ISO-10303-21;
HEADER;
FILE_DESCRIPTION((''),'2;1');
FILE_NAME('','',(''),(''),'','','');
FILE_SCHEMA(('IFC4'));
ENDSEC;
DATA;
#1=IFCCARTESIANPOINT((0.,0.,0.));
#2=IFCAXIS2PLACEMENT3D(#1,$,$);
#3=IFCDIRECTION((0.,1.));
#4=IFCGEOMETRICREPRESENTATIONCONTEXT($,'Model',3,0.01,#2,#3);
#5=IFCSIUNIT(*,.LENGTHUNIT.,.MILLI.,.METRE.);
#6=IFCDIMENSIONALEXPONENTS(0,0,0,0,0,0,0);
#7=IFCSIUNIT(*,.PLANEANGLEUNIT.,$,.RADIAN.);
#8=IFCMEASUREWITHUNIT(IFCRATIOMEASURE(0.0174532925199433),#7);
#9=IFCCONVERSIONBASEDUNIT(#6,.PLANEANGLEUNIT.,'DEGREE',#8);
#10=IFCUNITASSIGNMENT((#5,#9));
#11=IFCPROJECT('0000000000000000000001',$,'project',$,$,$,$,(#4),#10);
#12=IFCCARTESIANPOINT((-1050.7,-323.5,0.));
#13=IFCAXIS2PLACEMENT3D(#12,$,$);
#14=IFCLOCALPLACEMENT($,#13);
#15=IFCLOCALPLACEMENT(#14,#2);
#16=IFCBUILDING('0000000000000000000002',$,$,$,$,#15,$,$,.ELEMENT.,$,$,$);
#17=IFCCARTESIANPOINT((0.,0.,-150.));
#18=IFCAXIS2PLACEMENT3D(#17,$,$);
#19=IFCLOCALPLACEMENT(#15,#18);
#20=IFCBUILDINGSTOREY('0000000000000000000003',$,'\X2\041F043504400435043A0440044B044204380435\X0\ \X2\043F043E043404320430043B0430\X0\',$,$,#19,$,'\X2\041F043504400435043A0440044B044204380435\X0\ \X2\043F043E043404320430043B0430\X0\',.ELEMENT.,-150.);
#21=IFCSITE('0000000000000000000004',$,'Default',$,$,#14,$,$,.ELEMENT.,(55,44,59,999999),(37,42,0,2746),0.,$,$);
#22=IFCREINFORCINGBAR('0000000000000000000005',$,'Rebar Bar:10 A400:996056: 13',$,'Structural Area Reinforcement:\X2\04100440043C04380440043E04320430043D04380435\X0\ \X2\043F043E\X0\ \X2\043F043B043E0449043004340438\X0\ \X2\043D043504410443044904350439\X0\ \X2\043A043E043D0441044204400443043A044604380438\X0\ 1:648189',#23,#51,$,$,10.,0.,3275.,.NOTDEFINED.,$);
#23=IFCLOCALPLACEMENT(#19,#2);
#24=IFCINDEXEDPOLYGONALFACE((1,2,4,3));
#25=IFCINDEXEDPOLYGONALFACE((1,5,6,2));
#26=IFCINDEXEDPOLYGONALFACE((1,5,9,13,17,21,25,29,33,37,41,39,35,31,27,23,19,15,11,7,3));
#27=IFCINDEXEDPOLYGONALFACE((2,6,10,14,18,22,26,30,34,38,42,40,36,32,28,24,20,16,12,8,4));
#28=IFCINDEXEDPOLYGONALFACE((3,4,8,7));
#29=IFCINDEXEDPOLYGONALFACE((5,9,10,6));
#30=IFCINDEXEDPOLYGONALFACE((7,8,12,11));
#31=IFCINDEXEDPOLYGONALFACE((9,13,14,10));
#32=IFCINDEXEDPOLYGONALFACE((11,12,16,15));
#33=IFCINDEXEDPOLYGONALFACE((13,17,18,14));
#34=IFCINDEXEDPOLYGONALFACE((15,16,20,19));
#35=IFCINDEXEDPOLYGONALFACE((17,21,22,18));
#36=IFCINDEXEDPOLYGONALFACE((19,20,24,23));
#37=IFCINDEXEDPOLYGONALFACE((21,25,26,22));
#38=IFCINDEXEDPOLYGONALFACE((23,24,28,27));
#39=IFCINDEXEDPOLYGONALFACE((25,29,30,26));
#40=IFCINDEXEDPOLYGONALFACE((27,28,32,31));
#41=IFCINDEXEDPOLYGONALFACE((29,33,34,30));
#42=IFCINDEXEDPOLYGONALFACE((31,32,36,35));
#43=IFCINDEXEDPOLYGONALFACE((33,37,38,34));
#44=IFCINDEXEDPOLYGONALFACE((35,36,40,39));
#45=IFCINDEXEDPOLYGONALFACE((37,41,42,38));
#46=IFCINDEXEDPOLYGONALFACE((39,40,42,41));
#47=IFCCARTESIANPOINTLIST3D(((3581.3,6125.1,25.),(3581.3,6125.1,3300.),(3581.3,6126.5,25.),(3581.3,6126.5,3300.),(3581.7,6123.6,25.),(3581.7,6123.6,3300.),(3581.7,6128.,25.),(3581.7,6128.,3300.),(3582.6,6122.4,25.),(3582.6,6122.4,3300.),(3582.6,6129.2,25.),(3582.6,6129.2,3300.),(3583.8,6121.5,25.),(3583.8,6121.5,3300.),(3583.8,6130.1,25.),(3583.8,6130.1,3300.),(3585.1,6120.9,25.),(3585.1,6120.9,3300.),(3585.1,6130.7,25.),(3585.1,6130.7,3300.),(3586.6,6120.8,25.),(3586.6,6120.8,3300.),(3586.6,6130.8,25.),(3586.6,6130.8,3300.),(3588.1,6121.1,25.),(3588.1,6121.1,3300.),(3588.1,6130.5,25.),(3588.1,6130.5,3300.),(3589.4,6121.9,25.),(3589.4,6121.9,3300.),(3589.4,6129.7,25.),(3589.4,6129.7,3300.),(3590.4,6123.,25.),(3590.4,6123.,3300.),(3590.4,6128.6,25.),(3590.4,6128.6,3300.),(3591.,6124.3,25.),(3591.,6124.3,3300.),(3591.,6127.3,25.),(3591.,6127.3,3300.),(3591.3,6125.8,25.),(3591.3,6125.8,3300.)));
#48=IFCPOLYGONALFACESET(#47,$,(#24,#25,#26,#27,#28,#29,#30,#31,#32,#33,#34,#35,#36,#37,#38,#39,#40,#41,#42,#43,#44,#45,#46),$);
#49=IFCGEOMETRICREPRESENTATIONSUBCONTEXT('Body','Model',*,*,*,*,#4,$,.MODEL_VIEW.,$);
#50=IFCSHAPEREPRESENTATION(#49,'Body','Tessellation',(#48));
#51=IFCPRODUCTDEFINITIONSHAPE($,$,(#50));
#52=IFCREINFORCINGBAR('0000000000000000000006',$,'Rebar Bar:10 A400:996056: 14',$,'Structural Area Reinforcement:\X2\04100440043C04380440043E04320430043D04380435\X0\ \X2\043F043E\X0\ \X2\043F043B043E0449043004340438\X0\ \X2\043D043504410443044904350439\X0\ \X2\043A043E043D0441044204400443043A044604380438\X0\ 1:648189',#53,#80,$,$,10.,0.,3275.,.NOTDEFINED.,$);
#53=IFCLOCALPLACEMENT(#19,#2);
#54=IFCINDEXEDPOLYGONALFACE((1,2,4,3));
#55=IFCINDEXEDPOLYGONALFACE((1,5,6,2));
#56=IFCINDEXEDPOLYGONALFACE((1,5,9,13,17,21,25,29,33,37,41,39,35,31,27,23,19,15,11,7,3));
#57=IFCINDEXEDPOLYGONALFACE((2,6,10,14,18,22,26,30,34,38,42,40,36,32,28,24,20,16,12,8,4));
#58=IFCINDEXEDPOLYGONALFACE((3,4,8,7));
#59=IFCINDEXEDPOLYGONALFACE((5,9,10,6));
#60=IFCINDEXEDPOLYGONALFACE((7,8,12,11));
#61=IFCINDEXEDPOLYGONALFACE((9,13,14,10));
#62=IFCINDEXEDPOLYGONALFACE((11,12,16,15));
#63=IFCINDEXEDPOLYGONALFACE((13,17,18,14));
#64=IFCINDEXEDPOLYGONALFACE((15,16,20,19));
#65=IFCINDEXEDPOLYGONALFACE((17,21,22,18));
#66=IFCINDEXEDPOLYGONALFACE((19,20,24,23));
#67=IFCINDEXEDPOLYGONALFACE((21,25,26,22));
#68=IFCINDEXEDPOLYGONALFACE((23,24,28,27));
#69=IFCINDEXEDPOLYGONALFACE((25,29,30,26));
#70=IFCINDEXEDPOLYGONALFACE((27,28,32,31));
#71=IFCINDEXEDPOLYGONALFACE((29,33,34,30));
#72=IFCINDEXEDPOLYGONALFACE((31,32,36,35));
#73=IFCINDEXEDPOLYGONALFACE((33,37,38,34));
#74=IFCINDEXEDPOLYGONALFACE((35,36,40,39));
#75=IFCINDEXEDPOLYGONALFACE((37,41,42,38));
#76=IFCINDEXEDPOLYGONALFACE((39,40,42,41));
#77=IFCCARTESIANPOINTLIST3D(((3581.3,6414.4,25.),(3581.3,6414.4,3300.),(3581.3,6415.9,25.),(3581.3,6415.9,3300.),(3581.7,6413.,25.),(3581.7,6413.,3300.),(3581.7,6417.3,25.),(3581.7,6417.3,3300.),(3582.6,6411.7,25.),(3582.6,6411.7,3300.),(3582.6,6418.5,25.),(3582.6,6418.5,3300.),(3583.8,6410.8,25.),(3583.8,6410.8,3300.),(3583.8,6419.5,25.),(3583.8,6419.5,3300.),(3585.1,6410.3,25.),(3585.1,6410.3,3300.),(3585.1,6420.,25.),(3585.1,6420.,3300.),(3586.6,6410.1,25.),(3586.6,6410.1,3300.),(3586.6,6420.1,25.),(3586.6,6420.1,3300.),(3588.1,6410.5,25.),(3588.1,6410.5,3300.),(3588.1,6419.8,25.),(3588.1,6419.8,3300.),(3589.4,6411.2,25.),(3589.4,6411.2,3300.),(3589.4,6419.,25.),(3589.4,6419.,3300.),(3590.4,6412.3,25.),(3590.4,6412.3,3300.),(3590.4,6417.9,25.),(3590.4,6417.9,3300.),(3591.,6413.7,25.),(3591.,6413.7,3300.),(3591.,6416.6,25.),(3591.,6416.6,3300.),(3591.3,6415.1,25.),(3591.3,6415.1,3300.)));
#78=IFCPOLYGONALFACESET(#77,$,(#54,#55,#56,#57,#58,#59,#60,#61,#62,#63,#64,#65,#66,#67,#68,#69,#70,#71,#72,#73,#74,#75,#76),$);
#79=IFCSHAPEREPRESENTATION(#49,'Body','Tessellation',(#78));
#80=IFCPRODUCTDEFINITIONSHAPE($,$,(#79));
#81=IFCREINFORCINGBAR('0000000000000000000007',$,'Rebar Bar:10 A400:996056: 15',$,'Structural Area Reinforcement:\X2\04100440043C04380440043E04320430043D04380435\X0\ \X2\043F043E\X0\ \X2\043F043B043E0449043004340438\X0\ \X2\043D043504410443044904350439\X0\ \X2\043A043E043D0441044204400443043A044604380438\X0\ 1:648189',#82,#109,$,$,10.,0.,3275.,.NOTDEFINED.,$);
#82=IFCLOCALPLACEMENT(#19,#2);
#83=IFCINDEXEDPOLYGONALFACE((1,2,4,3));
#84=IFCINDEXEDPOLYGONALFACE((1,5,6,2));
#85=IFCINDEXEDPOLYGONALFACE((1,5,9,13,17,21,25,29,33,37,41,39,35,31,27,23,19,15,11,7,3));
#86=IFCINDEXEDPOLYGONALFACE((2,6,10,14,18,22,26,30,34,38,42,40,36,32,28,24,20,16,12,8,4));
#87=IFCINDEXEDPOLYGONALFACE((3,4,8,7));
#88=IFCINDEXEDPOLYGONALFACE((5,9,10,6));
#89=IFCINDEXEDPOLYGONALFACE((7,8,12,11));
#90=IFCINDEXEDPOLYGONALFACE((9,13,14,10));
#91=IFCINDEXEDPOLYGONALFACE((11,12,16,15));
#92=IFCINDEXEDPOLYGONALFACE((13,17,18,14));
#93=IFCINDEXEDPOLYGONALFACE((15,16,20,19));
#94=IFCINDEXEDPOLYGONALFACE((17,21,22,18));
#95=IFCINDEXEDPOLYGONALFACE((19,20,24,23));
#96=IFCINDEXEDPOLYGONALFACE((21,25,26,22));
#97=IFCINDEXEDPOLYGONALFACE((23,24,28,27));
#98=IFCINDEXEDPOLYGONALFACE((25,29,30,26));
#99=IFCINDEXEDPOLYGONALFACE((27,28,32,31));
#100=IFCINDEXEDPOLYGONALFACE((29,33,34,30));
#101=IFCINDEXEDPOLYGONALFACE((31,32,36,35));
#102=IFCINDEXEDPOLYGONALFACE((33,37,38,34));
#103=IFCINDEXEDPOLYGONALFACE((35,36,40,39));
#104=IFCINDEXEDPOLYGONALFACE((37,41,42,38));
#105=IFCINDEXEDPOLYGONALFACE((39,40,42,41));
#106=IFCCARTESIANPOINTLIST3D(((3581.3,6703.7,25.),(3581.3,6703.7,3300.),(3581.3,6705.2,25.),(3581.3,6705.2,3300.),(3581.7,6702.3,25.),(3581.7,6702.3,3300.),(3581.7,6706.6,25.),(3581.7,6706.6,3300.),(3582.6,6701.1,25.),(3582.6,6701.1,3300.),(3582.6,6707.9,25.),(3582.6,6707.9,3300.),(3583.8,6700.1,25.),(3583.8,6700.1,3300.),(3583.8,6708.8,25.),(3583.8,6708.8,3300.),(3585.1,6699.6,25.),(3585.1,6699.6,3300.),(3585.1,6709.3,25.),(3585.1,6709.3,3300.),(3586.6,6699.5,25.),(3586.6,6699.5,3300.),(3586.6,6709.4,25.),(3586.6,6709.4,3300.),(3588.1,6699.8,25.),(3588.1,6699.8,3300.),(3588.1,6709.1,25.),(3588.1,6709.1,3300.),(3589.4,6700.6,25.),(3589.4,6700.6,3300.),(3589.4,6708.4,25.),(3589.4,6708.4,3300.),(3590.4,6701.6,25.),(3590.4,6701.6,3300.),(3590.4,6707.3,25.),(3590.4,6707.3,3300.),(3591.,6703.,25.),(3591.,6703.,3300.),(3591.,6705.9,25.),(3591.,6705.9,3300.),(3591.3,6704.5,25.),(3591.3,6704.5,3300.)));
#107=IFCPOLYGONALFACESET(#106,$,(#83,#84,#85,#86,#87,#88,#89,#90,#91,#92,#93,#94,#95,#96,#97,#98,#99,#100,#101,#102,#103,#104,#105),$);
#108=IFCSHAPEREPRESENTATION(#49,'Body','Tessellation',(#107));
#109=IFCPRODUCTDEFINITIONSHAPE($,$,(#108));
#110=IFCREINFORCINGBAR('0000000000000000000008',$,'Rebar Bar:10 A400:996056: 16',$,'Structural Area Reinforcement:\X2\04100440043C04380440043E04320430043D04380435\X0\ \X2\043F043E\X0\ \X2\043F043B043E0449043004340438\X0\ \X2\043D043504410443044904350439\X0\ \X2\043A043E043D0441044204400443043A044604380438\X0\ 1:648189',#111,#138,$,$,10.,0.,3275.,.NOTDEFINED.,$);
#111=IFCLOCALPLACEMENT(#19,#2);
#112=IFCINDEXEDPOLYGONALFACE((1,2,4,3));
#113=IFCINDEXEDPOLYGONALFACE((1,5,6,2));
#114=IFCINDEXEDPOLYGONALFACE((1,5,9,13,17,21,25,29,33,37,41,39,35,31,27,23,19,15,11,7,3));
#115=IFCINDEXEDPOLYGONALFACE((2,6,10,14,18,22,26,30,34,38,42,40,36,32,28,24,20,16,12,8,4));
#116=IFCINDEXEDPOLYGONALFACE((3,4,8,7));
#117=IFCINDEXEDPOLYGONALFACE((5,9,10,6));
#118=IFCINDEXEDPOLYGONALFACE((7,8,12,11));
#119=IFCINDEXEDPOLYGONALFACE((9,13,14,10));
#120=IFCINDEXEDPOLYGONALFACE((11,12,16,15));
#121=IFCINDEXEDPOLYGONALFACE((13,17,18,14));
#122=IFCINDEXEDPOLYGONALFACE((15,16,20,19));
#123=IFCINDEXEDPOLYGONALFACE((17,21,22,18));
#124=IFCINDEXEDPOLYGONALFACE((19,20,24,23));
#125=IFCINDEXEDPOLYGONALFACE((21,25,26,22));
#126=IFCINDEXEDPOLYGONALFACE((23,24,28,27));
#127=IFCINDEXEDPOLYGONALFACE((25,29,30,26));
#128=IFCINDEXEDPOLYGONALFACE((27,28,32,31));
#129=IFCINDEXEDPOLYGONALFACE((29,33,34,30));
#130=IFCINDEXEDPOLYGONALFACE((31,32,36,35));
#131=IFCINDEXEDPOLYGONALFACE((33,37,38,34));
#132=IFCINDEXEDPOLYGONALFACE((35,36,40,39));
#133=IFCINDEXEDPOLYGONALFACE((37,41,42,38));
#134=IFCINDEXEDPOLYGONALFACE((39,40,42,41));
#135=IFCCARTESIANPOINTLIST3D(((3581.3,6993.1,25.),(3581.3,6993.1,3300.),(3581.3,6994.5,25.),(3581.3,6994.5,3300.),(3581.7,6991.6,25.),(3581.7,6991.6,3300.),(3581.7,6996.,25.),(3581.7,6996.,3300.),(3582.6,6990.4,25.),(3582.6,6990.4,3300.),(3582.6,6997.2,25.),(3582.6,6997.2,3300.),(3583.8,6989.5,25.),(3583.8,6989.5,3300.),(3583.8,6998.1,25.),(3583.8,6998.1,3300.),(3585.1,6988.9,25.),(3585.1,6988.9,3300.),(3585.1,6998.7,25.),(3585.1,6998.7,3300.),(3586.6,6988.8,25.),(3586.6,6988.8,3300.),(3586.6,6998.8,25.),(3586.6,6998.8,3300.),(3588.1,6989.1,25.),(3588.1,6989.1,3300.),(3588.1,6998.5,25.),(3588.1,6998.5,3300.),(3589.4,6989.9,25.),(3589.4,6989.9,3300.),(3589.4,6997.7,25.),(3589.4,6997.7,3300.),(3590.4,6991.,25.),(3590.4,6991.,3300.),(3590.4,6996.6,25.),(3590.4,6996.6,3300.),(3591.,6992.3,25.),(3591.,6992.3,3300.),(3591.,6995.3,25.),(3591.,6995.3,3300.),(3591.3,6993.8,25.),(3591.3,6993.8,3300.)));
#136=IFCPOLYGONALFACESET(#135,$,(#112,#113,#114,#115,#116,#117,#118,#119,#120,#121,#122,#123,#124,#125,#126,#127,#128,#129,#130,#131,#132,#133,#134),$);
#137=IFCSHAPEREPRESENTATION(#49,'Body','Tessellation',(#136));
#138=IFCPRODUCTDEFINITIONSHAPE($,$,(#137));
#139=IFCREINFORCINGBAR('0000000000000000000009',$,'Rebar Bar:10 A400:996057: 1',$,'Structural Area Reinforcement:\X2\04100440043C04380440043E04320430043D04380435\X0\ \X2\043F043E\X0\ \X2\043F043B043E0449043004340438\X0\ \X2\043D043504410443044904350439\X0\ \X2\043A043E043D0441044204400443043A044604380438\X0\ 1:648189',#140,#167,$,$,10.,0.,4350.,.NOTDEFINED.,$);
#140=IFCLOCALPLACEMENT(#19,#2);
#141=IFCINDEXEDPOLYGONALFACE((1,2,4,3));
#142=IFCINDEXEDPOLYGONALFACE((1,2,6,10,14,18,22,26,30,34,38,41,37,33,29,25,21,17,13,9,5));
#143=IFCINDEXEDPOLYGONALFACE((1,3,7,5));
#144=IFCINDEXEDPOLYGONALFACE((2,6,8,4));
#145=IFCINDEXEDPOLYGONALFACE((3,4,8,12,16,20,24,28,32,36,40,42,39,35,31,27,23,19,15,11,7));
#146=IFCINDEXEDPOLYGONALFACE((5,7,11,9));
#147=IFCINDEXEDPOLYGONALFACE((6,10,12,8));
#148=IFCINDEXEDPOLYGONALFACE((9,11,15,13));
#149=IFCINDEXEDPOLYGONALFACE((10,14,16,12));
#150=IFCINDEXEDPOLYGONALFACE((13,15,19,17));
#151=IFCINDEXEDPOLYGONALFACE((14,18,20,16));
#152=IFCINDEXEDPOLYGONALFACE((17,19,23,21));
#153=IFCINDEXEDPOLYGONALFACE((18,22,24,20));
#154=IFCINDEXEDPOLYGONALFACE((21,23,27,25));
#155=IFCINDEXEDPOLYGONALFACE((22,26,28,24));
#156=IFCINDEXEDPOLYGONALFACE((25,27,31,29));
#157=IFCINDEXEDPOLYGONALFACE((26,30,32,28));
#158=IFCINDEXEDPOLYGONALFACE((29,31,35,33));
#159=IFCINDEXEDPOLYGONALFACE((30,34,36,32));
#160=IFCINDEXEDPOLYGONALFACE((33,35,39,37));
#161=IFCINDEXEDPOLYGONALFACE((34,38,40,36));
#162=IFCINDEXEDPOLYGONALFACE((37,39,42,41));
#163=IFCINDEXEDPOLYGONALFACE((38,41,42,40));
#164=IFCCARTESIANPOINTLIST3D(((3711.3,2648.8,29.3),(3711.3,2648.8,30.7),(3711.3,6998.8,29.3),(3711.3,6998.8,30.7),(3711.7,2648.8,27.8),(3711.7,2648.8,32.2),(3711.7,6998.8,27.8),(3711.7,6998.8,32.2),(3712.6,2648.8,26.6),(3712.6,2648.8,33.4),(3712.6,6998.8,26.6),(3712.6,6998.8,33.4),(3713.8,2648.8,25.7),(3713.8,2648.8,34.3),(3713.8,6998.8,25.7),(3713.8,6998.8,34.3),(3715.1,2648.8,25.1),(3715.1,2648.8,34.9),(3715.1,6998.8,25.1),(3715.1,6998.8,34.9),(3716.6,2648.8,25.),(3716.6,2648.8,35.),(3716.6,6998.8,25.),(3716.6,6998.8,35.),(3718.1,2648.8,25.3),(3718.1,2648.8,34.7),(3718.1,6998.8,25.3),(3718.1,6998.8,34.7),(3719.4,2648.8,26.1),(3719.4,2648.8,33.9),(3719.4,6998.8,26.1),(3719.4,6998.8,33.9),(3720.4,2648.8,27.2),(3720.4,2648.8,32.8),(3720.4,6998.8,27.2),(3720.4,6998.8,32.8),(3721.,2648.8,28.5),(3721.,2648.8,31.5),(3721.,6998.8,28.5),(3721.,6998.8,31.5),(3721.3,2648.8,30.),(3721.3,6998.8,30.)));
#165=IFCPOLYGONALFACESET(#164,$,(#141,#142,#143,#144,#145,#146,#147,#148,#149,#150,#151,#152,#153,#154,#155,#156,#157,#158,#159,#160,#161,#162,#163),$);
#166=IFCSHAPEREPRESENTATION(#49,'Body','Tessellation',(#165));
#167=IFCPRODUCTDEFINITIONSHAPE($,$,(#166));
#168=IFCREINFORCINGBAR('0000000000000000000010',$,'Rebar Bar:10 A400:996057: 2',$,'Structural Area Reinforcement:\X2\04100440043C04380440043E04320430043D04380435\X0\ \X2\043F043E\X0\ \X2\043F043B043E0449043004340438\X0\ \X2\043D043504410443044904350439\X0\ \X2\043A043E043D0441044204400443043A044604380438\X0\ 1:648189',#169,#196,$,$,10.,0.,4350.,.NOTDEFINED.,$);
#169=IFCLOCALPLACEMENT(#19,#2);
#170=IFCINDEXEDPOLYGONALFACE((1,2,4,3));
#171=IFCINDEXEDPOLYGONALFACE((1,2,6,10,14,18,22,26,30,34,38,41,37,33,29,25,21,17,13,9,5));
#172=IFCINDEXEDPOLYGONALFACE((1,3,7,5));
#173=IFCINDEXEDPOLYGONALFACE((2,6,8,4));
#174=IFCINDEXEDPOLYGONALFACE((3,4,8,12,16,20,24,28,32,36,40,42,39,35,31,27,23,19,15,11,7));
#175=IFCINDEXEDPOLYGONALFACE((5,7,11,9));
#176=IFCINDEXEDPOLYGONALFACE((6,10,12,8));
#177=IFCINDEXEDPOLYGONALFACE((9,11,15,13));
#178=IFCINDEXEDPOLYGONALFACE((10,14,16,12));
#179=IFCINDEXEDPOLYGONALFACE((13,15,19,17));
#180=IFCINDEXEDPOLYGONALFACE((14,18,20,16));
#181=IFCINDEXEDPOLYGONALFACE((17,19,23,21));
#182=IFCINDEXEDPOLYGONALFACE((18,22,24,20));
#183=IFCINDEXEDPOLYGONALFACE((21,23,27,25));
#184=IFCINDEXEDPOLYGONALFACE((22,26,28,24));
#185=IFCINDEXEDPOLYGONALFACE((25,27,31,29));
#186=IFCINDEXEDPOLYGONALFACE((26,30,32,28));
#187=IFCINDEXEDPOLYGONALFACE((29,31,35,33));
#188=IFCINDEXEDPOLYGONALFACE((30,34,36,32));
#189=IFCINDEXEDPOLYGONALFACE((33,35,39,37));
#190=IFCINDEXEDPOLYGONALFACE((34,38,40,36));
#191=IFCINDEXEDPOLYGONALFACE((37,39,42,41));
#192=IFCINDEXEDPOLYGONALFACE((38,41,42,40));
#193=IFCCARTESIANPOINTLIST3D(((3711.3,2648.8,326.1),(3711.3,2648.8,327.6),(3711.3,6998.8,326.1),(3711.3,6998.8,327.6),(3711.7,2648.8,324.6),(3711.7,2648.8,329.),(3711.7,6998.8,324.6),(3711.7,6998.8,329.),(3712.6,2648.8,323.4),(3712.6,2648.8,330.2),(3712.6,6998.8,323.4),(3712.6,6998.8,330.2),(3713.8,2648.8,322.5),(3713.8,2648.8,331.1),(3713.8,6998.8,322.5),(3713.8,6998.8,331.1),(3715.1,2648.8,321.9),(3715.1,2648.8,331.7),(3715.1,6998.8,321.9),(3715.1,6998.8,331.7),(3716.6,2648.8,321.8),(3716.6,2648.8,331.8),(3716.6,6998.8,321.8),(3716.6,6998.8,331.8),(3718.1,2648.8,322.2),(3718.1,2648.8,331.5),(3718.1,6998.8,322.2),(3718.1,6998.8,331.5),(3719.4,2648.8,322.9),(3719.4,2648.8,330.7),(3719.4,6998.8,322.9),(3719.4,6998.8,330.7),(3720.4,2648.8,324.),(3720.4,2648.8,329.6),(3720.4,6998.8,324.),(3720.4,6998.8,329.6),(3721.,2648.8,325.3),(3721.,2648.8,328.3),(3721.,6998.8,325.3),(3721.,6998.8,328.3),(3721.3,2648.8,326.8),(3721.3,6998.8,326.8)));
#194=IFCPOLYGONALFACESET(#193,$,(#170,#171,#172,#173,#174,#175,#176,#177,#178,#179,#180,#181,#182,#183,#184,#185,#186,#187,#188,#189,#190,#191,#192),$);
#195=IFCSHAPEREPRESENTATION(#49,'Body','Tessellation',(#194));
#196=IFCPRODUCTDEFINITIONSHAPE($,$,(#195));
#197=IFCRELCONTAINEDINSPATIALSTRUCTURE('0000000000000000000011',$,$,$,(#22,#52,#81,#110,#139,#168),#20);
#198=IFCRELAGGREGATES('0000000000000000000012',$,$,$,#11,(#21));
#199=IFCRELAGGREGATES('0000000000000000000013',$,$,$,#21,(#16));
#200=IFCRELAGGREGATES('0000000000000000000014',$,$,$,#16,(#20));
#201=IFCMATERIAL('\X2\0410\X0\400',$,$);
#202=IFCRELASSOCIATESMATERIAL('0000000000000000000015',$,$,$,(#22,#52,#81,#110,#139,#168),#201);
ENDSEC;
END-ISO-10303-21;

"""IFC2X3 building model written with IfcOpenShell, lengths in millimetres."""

from ifc_helpers import new_model, entity, si_unit, converted_unit, direction, frame, origin, place, context, subcontext, project, spatial, material, element, save


model = new_model("IFC2X3")

# Units and contexts
model_context = context("Model", 3, precision=0.01, world=origin(), true_north=direction((0.0, 1.0)))
body_context = subcontext(model_context, "Body", "Model", "MODEL_VIEW")
ifc_project = project(units=[si_unit("LENGTHUNIT", "METRE", prefix="MILLI"), converted_unit("PLANEANGLEUNIT", "DEGREE", entity("IfcRatioMeasure", 0.0174532925199433), si_unit("PLANEANGLEUNIT", "RADIAN"), dimensions=[0, 0, 0, 0, 0, 0, 0])], contexts=[model_context])

# Site, building, storey
site_placement = place(None, frame((-1050.7, -323.5, 0.0)))
site = spatial("IfcSite", under=ifc_project, at=site_placement, Name="Default", CompositionType="ELEMENT", RefLatitude=(55, 44, 59, 999999), RefLongitude=(37, 42, 0, 2746), RefElevation=0.0)
building_placement = place(site_placement, origin())
building = spatial("IfcBuilding", under=site, at=building_placement, CompositionType="ELEMENT")
storey_placement = place(building_placement, frame((0.0, 0.0, -150.0)))
storey = spatial("IfcBuildingStorey", under=building, at=storey_placement, Name="Перекрытие подвала", LongName="Перекрытие подвала", CompositionType="ELEMENT", Elevation=-150.0)

# Reinforcing bars
ifc_material = material(Name="А400")
reinforcing_bar_1_placement = place(storey_placement, origin())
element("IfcReinforcingBar", 1, at=reinforcing_bar_1_placement, inside=storey, material=ifc_material, Name="Rebar Bar:10 A400:996056: 13", ObjectType="Structural Area Reinforcement:Армирование по площади несущей конструкции 1:648189", BarLength=3275.0, BarRole="NOTDEFINED", CrossSectionArea=0.0, NominalDiameter=10.0, context=body_context, shape_type="AdvancedSweptSolid", body=[
    entity("IfcSweptDiskSolid", entity("IfcCompositeCurve", [entity("IfcCompositeCurveSegment", "CONTINUOUS", True, entity("IfcPolyline", [entity("IfcCartesianPoint", [3586.3, 6125.8, 25.0]), entity("IfcCartesianPoint", [3586.3, 6125.8, 3300.0])]))], False), 5.0, None, 0.0, 1.0),
])
reinforcing_bar_2_placement = place(storey_placement, origin())
element("IfcReinforcingBar", 2, at=reinforcing_bar_2_placement, inside=storey, material=ifc_material, Name="Rebar Bar:10 A400:996056: 14", ObjectType="Structural Area Reinforcement:Армирование по площади несущей конструкции 1:648189", BarLength=3275.0, BarRole="NOTDEFINED", CrossSectionArea=0.0, NominalDiameter=10.0, context=body_context, shape_type="AdvancedSweptSolid", body=[
    entity("IfcSweptDiskSolid", entity("IfcCompositeCurve", [entity("IfcCompositeCurveSegment", "CONTINUOUS", True, entity("IfcPolyline", [entity("IfcCartesianPoint", [3586.3, 6415.1, 25.0]), entity("IfcCartesianPoint", [3586.3, 6415.1, 3300.0])]))], False), 5.0, None, 0.0, 1.0),
])
reinforcing_bar_3_placement = place(storey_placement, origin())
element("IfcReinforcingBar", 3, at=reinforcing_bar_3_placement, inside=storey, material=ifc_material, Name="Rebar Bar:10 A400:996056: 15", ObjectType="Structural Area Reinforcement:Армирование по площади несущей конструкции 1:648189", BarLength=3275.0, BarRole="NOTDEFINED", CrossSectionArea=0.0, NominalDiameter=10.0, context=body_context, shape_type="AdvancedSweptSolid", body=[
    entity("IfcSweptDiskSolid", entity("IfcCompositeCurve", [entity("IfcCompositeCurveSegment", "CONTINUOUS", True, entity("IfcPolyline", [entity("IfcCartesianPoint", [3586.3, 6704.5, 25.0]), entity("IfcCartesianPoint", [3586.3, 6704.5, 3300.0])]))], False), 5.0, None, 0.0, 1.0),
])
reinforcing_bar_4_placement = place(storey_placement, origin())
element("IfcReinforcingBar", 4, at=reinforcing_bar_4_placement, inside=storey, material=ifc_material, Name="Rebar Bar:10 A400:996056: 16", ObjectType="Structural Area Reinforcement:Армирование по площади несущей конструкции 1:648189", BarLength=3275.0, BarRole="NOTDEFINED", CrossSectionArea=0.0, NominalDiameter=10.0, context=body_context, shape_type="AdvancedSweptSolid", body=[
    entity("IfcSweptDiskSolid", entity("IfcCompositeCurve", [entity("IfcCompositeCurveSegment", "CONTINUOUS", True, entity("IfcPolyline", [entity("IfcCartesianPoint", [3586.3, 6993.8, 25.0]), entity("IfcCartesianPoint", [3586.3, 6993.8, 3300.0])]))], False), 5.0, None, 0.0, 1.0),
])
reinforcing_bar_5_placement = place(storey_placement, origin())
element("IfcReinforcingBar", 5, at=reinforcing_bar_5_placement, inside=storey, material=ifc_material, Name="Rebar Bar:10 A400:996057: 1", ObjectType="Structural Area Reinforcement:Армирование по площади несущей конструкции 1:648189", BarLength=4350.0, BarRole="NOTDEFINED", CrossSectionArea=0.0, NominalDiameter=10.0, context=body_context, shape_type="AdvancedSweptSolid", body=[
    entity("IfcSweptDiskSolid", entity("IfcCompositeCurve", [entity("IfcCompositeCurveSegment", "CONTINUOUS", True, entity("IfcPolyline", [entity("IfcCartesianPoint", [3716.3, 2648.8, 30.0]), entity("IfcCartesianPoint", [3716.3, 6998.8, 30.0])]))], False), 5.0, None, 0.0, 1.0),
])
reinforcing_bar_6_placement = place(storey_placement, origin())
element("IfcReinforcingBar", 6, at=reinforcing_bar_6_placement, inside=storey, material=ifc_material, Name="Rebar Bar:10 A400:996057: 2", ObjectType="Structural Area Reinforcement:Армирование по площади несущей конструкции 1:648189", BarLength=4350.0, BarRole="NOTDEFINED", CrossSectionArea=0.0, NominalDiameter=10.0, context=body_context, shape_type="AdvancedSweptSolid", body=[
    entity("IfcSweptDiskSolid", entity("IfcCompositeCurve", [entity("IfcCompositeCurveSegment", "CONTINUOUS", True, entity("IfcPolyline", [entity("IfcCartesianPoint", [3716.3, 2648.8, 326.8]), entity("IfcCartesianPoint", [3716.3, 6998.8, 326.8])]))], False), 5.0, None, 0.0, 1.0),
])

save(model, "model.ifc")
